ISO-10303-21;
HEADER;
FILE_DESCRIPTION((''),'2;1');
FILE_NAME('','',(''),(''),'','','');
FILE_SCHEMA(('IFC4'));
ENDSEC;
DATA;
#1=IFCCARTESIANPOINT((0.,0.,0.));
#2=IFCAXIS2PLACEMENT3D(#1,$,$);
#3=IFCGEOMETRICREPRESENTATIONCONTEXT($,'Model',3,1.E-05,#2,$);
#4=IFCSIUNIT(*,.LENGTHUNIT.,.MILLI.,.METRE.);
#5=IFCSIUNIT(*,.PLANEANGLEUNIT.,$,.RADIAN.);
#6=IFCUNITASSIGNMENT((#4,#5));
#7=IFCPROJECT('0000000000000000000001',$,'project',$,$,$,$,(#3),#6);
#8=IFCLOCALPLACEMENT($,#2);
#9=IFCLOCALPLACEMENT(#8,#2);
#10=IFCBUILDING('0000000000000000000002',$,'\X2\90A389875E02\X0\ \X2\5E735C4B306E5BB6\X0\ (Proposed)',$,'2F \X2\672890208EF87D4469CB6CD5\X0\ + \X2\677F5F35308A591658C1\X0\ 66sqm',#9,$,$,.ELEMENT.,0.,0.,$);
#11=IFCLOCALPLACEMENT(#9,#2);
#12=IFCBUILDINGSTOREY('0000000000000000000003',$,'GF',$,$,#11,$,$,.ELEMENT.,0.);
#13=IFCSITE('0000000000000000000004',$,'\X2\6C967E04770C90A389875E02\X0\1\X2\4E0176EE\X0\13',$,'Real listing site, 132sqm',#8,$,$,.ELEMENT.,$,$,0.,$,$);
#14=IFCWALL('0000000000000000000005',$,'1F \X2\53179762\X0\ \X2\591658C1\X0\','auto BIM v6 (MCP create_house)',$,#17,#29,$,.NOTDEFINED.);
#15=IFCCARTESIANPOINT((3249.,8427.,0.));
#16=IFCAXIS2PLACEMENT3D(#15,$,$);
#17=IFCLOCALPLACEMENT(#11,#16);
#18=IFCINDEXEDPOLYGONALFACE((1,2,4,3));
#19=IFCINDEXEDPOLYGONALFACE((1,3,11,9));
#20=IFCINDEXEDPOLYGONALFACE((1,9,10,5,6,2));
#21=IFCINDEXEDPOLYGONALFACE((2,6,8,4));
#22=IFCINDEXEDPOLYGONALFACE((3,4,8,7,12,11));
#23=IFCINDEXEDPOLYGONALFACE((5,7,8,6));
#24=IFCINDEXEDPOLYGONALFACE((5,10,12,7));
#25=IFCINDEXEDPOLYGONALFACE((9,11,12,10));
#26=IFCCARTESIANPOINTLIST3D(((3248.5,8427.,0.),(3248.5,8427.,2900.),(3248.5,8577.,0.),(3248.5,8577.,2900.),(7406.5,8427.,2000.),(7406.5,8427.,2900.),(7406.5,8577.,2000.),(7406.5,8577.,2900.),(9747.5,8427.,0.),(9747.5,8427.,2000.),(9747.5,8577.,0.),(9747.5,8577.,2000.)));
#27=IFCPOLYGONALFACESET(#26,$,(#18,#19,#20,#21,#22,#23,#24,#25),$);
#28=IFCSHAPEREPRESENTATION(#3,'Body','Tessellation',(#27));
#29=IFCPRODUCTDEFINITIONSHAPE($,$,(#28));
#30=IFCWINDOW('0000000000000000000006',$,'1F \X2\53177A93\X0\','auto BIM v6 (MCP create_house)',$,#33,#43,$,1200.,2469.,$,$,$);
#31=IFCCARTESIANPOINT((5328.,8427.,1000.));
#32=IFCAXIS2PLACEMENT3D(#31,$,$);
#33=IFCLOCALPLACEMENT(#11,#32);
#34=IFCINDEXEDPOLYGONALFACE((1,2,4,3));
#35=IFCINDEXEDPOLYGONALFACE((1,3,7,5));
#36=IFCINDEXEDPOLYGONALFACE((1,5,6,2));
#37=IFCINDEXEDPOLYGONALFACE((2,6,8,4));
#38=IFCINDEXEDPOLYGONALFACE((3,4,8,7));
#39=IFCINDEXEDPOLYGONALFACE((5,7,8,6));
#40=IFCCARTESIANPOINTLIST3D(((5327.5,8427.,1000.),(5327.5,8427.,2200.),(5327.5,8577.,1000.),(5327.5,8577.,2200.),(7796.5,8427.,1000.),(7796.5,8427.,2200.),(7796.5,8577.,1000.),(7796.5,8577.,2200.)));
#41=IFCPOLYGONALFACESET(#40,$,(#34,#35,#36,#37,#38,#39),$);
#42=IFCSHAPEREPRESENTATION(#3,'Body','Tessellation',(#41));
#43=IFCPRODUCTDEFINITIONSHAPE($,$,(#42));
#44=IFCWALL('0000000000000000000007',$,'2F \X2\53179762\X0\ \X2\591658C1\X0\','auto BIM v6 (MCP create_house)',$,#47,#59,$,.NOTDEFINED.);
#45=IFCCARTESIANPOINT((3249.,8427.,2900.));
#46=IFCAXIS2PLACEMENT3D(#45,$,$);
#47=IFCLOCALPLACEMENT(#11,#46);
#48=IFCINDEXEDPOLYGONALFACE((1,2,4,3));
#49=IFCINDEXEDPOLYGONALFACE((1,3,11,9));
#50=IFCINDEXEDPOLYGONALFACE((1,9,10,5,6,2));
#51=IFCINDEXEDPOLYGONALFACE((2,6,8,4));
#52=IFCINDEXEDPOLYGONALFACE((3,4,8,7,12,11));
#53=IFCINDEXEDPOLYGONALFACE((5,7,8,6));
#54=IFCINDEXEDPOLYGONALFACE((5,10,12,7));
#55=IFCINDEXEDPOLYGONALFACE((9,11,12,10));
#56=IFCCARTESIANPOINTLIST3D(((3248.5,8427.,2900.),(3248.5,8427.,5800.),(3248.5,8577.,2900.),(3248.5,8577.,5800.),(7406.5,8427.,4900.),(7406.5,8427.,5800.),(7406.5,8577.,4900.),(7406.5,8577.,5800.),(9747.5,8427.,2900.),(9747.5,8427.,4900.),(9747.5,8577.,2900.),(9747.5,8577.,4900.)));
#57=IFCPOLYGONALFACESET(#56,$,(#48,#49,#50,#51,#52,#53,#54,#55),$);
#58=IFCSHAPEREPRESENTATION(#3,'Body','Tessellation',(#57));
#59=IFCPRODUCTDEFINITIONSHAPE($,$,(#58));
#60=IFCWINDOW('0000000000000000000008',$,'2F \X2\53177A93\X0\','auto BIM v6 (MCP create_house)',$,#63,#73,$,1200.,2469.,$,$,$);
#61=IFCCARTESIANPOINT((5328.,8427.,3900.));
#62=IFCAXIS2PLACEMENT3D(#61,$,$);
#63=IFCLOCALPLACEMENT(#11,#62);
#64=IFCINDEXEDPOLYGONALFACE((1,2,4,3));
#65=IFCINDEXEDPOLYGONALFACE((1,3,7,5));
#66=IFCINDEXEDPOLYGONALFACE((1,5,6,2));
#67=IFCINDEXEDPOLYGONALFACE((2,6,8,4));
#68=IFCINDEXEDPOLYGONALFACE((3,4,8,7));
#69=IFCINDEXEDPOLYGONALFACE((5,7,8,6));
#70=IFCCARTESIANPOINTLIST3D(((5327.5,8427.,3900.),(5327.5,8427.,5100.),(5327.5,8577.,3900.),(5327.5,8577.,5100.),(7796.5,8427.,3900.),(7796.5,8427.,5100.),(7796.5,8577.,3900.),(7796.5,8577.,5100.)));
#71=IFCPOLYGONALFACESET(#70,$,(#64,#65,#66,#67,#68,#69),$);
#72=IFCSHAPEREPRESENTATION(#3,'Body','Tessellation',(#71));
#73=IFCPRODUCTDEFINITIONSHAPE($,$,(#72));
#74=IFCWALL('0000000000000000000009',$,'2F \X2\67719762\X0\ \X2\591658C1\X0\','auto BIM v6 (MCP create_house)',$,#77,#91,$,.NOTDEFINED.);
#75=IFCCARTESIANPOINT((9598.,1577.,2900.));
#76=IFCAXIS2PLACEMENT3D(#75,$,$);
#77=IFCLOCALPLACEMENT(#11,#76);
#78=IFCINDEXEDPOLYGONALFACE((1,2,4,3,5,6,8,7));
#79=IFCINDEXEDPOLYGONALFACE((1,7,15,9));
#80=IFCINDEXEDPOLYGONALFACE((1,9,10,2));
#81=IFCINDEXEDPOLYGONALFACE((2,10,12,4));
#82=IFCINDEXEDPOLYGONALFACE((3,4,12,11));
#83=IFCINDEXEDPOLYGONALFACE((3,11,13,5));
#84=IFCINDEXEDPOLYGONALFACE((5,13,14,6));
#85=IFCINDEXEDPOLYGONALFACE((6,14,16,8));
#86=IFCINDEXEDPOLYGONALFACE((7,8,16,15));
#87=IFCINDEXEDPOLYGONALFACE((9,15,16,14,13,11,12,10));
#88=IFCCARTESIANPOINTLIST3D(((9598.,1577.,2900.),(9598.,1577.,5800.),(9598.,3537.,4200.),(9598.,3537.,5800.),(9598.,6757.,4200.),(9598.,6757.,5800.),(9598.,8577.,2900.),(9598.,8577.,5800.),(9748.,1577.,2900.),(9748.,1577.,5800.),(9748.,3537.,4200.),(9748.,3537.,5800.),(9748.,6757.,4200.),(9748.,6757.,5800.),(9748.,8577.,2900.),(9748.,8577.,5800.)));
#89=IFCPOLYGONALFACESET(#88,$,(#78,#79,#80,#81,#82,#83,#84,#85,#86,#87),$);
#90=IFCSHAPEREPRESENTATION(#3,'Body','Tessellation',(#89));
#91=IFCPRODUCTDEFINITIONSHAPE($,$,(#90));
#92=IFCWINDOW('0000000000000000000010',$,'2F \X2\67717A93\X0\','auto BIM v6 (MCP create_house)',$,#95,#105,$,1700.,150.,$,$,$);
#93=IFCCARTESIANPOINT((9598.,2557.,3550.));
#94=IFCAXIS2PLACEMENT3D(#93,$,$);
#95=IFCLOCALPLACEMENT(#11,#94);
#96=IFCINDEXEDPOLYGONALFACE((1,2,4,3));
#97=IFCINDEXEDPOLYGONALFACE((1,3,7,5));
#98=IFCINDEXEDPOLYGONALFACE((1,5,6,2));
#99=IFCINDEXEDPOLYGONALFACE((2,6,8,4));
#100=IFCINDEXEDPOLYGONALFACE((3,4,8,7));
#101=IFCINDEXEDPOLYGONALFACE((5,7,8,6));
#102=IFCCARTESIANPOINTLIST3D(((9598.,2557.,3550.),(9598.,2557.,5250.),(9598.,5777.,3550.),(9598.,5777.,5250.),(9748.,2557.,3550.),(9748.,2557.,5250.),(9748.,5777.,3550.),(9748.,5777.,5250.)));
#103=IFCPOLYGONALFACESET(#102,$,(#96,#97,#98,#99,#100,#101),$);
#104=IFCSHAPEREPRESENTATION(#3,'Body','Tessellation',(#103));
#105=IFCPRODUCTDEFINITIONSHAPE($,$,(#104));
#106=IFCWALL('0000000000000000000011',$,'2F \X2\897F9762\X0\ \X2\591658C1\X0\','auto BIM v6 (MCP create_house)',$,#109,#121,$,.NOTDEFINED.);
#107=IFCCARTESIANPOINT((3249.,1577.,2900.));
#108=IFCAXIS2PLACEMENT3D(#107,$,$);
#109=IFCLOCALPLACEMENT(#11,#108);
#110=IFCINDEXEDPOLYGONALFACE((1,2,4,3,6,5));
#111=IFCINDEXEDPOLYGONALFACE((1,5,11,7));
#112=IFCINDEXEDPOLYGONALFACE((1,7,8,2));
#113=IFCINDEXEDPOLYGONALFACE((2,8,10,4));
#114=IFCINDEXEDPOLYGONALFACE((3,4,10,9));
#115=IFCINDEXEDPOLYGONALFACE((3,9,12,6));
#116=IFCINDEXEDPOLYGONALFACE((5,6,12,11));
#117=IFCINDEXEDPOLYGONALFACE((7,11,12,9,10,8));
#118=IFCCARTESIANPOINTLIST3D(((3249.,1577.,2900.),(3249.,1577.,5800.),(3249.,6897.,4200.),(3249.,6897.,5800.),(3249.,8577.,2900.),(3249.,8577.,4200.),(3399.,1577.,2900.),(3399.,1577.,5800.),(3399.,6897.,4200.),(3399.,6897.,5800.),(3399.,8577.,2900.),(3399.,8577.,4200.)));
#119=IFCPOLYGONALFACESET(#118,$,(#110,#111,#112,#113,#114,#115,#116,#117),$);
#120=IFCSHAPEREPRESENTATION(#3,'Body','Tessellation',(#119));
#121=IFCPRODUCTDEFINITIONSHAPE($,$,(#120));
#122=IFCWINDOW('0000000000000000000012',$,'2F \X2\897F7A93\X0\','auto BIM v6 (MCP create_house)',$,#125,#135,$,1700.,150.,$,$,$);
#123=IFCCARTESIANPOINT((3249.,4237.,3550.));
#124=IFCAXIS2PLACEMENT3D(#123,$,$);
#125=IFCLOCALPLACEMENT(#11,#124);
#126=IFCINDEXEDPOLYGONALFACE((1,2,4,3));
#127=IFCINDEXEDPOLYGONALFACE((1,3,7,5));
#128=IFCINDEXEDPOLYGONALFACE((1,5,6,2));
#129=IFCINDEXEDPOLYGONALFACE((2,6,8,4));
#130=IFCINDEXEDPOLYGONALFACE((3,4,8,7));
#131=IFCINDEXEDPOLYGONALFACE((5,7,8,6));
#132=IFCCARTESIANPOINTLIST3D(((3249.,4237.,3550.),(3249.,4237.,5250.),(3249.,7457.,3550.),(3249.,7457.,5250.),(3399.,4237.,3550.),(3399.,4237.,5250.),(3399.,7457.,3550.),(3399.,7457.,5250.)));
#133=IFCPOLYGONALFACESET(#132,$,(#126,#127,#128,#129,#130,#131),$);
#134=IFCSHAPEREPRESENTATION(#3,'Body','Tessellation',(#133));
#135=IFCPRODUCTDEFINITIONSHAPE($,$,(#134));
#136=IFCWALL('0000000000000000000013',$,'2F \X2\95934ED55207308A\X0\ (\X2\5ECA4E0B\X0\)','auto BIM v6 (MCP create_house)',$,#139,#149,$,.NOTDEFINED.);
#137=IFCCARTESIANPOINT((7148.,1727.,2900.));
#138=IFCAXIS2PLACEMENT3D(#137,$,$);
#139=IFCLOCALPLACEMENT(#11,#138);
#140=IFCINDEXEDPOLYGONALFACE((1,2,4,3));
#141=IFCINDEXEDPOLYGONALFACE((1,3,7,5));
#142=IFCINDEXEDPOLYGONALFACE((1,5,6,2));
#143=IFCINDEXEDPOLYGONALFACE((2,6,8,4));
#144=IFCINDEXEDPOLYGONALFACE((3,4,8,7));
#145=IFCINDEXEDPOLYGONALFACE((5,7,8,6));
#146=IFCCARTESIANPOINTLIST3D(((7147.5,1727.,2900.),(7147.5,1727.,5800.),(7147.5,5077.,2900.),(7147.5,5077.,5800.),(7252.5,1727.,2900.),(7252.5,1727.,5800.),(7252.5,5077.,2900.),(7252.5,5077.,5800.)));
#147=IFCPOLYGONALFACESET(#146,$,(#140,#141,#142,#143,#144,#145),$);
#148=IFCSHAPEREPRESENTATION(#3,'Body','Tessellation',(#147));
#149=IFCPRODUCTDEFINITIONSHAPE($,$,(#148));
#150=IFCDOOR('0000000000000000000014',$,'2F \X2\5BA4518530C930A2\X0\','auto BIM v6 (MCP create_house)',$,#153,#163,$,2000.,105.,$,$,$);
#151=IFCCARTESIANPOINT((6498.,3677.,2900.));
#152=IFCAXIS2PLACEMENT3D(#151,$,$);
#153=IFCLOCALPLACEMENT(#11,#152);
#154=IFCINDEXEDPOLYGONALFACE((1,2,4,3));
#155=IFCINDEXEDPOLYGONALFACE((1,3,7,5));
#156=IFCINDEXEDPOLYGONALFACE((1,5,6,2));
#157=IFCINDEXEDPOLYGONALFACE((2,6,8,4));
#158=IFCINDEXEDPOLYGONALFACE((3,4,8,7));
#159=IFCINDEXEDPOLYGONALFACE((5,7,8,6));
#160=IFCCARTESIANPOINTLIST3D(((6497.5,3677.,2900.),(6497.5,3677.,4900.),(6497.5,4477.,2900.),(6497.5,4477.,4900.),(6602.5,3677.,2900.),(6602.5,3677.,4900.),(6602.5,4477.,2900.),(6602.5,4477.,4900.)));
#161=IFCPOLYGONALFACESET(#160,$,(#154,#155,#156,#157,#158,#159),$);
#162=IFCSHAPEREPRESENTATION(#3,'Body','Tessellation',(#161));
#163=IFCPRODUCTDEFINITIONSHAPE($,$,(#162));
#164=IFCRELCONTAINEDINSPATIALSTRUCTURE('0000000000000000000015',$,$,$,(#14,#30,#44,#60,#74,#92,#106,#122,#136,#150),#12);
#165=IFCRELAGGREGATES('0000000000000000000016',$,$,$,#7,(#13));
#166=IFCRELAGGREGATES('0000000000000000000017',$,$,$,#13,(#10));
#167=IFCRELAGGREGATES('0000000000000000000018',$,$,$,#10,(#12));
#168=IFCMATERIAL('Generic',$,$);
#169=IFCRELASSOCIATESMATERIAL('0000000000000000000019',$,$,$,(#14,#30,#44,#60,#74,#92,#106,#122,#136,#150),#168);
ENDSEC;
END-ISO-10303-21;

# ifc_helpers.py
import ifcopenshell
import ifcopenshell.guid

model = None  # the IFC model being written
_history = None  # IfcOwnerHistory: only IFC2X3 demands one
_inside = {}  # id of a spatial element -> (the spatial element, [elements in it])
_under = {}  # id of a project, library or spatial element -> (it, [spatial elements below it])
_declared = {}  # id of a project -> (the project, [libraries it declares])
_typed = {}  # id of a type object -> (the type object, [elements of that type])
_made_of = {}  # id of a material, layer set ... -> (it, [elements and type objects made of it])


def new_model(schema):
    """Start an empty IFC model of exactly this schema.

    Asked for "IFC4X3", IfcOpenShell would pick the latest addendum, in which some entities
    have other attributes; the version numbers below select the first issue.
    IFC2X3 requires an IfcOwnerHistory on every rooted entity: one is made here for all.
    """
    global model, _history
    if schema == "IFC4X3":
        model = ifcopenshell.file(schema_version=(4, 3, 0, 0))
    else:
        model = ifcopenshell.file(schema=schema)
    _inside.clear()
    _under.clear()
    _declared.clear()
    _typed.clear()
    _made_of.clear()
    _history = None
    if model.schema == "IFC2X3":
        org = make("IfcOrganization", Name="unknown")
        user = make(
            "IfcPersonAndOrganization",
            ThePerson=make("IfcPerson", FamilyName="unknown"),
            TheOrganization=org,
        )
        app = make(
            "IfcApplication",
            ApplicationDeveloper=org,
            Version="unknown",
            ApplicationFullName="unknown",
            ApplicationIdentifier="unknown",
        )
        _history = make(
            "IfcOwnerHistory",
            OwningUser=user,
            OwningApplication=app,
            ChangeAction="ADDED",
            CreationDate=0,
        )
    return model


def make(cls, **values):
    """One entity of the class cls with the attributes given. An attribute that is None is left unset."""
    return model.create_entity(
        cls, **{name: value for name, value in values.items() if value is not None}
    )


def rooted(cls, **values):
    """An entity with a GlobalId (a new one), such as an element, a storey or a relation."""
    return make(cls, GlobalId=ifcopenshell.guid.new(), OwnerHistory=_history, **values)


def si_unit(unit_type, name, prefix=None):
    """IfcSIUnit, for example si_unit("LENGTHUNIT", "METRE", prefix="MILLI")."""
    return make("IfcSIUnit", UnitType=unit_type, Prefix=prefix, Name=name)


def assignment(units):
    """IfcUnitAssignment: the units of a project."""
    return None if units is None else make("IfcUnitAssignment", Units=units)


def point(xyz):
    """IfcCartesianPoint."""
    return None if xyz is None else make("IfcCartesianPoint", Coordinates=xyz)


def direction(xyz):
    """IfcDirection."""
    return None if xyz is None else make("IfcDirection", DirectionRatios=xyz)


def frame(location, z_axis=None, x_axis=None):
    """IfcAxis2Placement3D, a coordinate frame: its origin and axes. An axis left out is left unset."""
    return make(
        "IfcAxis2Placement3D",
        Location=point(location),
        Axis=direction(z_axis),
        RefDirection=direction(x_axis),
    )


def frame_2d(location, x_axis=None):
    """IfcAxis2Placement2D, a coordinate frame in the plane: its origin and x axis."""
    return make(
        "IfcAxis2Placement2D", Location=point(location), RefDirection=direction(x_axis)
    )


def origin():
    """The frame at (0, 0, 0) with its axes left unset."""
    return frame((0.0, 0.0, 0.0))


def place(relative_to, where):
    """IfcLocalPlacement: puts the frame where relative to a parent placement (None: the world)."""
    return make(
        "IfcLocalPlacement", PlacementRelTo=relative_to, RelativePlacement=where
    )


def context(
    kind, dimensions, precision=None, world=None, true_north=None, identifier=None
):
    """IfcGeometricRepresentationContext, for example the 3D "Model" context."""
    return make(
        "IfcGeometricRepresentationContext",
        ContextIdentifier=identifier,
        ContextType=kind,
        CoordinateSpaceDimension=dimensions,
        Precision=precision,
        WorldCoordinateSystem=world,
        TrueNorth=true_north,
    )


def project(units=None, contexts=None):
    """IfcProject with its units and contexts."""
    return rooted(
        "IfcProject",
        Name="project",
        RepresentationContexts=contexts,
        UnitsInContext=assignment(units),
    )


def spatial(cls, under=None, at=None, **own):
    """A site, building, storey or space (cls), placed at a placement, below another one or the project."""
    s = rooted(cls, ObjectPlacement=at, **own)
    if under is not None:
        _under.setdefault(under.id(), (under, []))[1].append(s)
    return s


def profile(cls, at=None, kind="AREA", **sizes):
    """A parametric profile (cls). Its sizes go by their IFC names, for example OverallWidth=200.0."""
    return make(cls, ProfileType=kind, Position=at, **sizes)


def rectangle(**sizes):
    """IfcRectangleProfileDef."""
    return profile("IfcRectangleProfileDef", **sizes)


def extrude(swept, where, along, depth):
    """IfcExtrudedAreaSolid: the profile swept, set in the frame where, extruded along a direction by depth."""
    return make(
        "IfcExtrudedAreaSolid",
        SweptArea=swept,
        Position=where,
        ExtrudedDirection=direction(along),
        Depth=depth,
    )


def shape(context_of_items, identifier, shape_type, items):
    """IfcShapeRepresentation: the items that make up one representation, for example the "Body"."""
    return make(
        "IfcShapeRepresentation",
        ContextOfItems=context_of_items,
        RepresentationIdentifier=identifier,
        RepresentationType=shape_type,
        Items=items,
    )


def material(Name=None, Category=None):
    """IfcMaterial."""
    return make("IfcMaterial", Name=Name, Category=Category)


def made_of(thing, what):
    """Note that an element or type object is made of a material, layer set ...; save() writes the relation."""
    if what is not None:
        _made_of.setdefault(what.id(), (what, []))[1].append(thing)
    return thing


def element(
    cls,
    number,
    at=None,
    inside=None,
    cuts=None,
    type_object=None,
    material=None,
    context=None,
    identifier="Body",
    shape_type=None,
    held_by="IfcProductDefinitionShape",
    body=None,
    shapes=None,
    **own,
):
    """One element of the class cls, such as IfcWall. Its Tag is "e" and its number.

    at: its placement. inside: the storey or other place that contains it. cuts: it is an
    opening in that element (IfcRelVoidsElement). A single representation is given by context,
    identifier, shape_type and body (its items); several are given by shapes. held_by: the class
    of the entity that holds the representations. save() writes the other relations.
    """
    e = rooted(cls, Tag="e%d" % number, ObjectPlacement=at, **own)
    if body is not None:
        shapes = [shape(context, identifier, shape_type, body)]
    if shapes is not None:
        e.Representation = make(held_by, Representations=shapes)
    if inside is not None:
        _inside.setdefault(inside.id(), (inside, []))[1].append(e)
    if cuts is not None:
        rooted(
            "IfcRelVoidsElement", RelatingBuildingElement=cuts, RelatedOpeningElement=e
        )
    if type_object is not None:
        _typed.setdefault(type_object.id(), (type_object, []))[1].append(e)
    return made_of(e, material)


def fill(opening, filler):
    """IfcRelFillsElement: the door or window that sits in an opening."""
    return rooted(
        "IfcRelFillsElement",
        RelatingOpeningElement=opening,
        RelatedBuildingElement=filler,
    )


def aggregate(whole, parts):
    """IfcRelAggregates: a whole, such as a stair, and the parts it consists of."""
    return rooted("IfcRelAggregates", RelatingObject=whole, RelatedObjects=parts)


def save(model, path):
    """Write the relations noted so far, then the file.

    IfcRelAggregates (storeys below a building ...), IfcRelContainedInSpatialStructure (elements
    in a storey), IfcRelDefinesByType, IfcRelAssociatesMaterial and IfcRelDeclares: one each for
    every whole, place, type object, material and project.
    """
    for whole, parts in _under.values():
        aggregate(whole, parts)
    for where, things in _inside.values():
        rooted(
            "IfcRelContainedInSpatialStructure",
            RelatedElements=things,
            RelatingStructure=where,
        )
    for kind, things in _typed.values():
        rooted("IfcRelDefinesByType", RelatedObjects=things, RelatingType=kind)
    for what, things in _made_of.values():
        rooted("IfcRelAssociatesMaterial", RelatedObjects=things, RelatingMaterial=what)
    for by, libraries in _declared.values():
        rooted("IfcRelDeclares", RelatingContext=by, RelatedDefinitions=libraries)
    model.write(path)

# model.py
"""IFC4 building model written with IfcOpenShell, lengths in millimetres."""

from ifc_helpers import new_model, si_unit, frame, frame_2d, origin, place, context, project, spatial, rectangle, extrude, material, element, fill, save


model = new_model("IFC4")

# Units and contexts
model_context = context("Model", 3, precision=1e-05, world=origin())
ifc_project = project(units=[si_unit("LENGTHUNIT", "METRE", prefix="MILLI"), si_unit("PLANEANGLEUNIT", "RADIAN")], contexts=[model_context])

# Site, building, storey
site_placement = place(None, origin())
site = spatial("IfcSite", under=ifc_project, at=site_placement, Name="沖縄県那覇市1丁目13", ObjectType="Real listing site, 132sqm", CompositionType="ELEMENT", RefElevation=0.0)
building_placement = place(site_placement, origin())
building = spatial("IfcBuilding", under=site, at=building_placement, Name="那覇市 平屋の家 (Proposed)", ObjectType="2F 木造軸組構法 + 板張り外壁 66sqm", CompositionType="ELEMENT", ElevationOfRefHeight=0.0, ElevationOfTerrain=0.0)
storey_placement = place(building_placement, origin())
storey = spatial("IfcBuildingStorey", under=building, at=storey_placement, Name="GF", CompositionType="ELEMENT", Elevation=0.0)

# Wall, opening, window
ifc_material = material(Name="Generic")
wall_1_placement = place(storey_placement, frame((3249.0, 8427.0, 0.0)))
wall_1 = element("IfcWall", 1, at=wall_1_placement, inside=storey, material=ifc_material, Name="1F 北面 外壁", Description="auto BIM v6 (MCP create_house)", PredefinedType="NOTDEFINED", context=model_context, shape_type="SweptSolid", body=[
    extrude(rectangle(XDim=6499.0, YDim=150.0, at=frame_2d((3249.0, 75.0))), frame((3249.0, 8427.0, 0.0)), (0.0, 0.0, 1.0), 2900.0),
])
opening_1_placement = place(storey_placement, frame((5328.0, 8427.0, 1000.0)))
opening_1 = element("IfcOpeningElement", 2, at=opening_1_placement, cuts=wall_1, PredefinedType="NOTDEFINED", context=model_context, shape_type="SweptSolid", body=[
    extrude(rectangle(XDim=2469.0, YDim=150.0, at=frame_2d((1234.0, 75.0))), frame((5328.0, 8427.0, 1000.0)), (0.0, 0.0, 1.0), 1200.0),
])
window_1_placement = place(storey_placement, frame((5328.0, 8427.0, 1000.0)))
window_1 = element("IfcWindow", 3, at=window_1_placement, inside=storey, material=ifc_material, Name="1F 北窓", Description="auto BIM v6 (MCP create_house)", OverallHeight=1200.0, OverallWidth=2469.0, context=model_context, shape_type="SweptSolid", body=[
    extrude(rectangle(XDim=2469.0, YDim=150.0, at=frame_2d((1234.0, 75.0))), frame((5328.0, 8427.0, 1000.0)), (0.0, 0.0, 1.0), 1200.0),
])
fill(opening_1, window_1)

# Walls, openings, windows
wall_2_placement = place(storey_placement, frame((3249.0, 8427.0, 2900.0)))
wall_2 = element("IfcWall", 4, at=wall_2_placement, inside=storey, material=ifc_material, Name="2F 北面 外壁", Description="auto BIM v6 (MCP create_house)", PredefinedType="NOTDEFINED", context=model_context, shape_type="SweptSolid", body=[
    extrude(rectangle(XDim=6499.0, YDim=150.0, at=frame_2d((3249.0, 75.0))), frame((3249.0, 8427.0, 2900.0)), (0.0, 0.0, 1.0), 2900.0),
])
opening_2_placement = place(storey_placement, frame((5328.0, 8427.0, 3900.0)))
opening_2 = element("IfcOpeningElement", 5, at=opening_2_placement, cuts=wall_2, PredefinedType="NOTDEFINED", context=model_context, shape_type="SweptSolid", body=[
    extrude(rectangle(XDim=2469.0, YDim=150.0, at=frame_2d((1234.0, 75.0))), frame((5328.0, 8427.0, 3900.0)), (0.0, 0.0, 1.0), 1200.0),
])
window_2_placement = place(storey_placement, frame((5328.0, 8427.0, 3900.0)))
window_2 = element("IfcWindow", 6, at=window_2_placement, inside=storey, material=ifc_material, Name="2F 北窓", Description="auto BIM v6 (MCP create_house)", OverallHeight=1200.0, OverallWidth=2469.0, context=model_context, shape_type="SweptSolid", body=[
    extrude(rectangle(XDim=2469.0, YDim=150.0, at=frame_2d((1234.0, 75.0))), frame((5328.0, 8427.0, 3900.0)), (0.0, 0.0, 1.0), 1200.0),
])
fill(opening_2, window_2)
wall_3_placement = place(storey_placement, frame((9598.0, 1577.0, 2900.0)))
wall_3 = element("IfcWall", 7, at=wall_3_placement, inside=storey, material=ifc_material, Name="2F 東面 外壁", Description="auto BIM v6 (MCP create_house)", PredefinedType="NOTDEFINED", context=model_context, shape_type="SweptSolid", body=[
    extrude(rectangle(XDim=150.0, YDim=7000.0, at=frame_2d((75.0, 3500.0))), frame((9598.0, 1577.0, 2900.0)), (0.0, 0.0, 1.0), 2900.0),
])
opening_3_placement = place(storey_placement, frame((9598.0, 2557.0, 3550.0)))
opening_3 = element("IfcOpeningElement", 8, at=opening_3_placement, cuts=wall_3, PredefinedType="NOTDEFINED", context=model_context, shape_type="SweptSolid", body=[
    extrude(rectangle(XDim=150.0, YDim=3220.0, at=frame_2d((75.0, 1610.0))), frame((9598.0, 2557.0, 3550.0)), (0.0, 0.0, 1.0), 1700.0),
])
window_3_placement = place(storey_placement, frame((9598.0, 2557.0, 3550.0)))
window_3 = element("IfcWindow", 9, at=window_3_placement, inside=storey, material=ifc_material, Name="2F 東窓", Description="auto BIM v6 (MCP create_house)", OverallHeight=1700.0, OverallWidth=150.0, context=model_context, shape_type="SweptSolid", body=[
    extrude(rectangle(XDim=150.0, YDim=3220.0, at=frame_2d((75.0, 1610.0))), frame((9598.0, 2557.0, 3550.0)), (0.0, 0.0, 1.0), 1700.0),
])
fill(opening_3, window_3)
wall_4_placement = place(storey_placement, frame((3249.0, 1577.0, 2900.0)))
wall_4 = element("IfcWall", 10, at=wall_4_placement, inside=storey, material=ifc_material, Name="2F 西面 外壁", Description="auto BIM v6 (MCP create_house)", PredefinedType="NOTDEFINED", context=model_context, shape_type="SweptSolid", body=[
    extrude(rectangle(XDim=150.0, YDim=7000.0, at=frame_2d((75.0, 3500.0))), frame((3249.0, 1577.0, 2900.0)), (0.0, 0.0, 1.0), 2900.0),
])
opening_4_placement = place(storey_placement, frame((3249.0, 4237.0, 3550.0)))
opening_4 = element("IfcOpeningElement", 11, at=opening_4_placement, cuts=wall_4, PredefinedType="NOTDEFINED", context=model_context, shape_type="SweptSolid", body=[
    extrude(rectangle(XDim=150.0, YDim=3220.0, at=frame_2d((75.0, 1610.0))), frame((3249.0, 4237.0, 3550.0)), (0.0, 0.0, 1.0), 1700.0),
])
window_4_placement = place(storey_placement, frame((3249.0, 4237.0, 3550.0)))
window_4 = element("IfcWindow", 12, at=window_4_placement, inside=storey, material=ifc_material, Name="2F 西窓", Description="auto BIM v6 (MCP create_house)", OverallHeight=1700.0, OverallWidth=150.0, context=model_context, shape_type="SweptSolid", body=[
    extrude(rectangle(XDim=150.0, YDim=3220.0, at=frame_2d((75.0, 1610.0))), frame((3249.0, 4237.0, 3550.0)), (0.0, 0.0, 1.0), 1700.0),
])
fill(opening_4, window_4)

# Wall
wall_5_placement = place(storey_placement, frame((7148.0, 1727.0, 2900.0)))
element("IfcWall", 13, at=wall_5_placement, inside=storey, material=ifc_material, Name="2F 間仕切り (廊下)", Description="auto BIM v6 (MCP create_house)", PredefinedType="NOTDEFINED", context=model_context, shape_type="SweptSolid", body=[
    extrude(rectangle(XDim=105.0, YDim=3350.0, at=frame_2d((52.0, 1675.0))), frame((7148.0, 1727.0, 2900.0)), (0.0, 0.0, 1.0), 2900.0),
])

# Door
door_placement = place(storey_placement, frame((6498.0, 3677.0, 2900.0)))
element("IfcDoor", 14, at=door_placement, inside=storey, material=ifc_material, Name="2F 室内ドア", Description="auto BIM v6 (MCP create_house)", OverallHeight=2000.0, OverallWidth=105.0, context=model_context, shape_type="SweptSolid", body=[
    extrude(rectangle(XDim=105.0, YDim=800.0, at=frame_2d((52.0, 400.0))), frame((6498.0, 3677.0, 2900.0)), (0.0, 0.0, 1.0), 2000.0),
])

save(model, "model.ifc")
